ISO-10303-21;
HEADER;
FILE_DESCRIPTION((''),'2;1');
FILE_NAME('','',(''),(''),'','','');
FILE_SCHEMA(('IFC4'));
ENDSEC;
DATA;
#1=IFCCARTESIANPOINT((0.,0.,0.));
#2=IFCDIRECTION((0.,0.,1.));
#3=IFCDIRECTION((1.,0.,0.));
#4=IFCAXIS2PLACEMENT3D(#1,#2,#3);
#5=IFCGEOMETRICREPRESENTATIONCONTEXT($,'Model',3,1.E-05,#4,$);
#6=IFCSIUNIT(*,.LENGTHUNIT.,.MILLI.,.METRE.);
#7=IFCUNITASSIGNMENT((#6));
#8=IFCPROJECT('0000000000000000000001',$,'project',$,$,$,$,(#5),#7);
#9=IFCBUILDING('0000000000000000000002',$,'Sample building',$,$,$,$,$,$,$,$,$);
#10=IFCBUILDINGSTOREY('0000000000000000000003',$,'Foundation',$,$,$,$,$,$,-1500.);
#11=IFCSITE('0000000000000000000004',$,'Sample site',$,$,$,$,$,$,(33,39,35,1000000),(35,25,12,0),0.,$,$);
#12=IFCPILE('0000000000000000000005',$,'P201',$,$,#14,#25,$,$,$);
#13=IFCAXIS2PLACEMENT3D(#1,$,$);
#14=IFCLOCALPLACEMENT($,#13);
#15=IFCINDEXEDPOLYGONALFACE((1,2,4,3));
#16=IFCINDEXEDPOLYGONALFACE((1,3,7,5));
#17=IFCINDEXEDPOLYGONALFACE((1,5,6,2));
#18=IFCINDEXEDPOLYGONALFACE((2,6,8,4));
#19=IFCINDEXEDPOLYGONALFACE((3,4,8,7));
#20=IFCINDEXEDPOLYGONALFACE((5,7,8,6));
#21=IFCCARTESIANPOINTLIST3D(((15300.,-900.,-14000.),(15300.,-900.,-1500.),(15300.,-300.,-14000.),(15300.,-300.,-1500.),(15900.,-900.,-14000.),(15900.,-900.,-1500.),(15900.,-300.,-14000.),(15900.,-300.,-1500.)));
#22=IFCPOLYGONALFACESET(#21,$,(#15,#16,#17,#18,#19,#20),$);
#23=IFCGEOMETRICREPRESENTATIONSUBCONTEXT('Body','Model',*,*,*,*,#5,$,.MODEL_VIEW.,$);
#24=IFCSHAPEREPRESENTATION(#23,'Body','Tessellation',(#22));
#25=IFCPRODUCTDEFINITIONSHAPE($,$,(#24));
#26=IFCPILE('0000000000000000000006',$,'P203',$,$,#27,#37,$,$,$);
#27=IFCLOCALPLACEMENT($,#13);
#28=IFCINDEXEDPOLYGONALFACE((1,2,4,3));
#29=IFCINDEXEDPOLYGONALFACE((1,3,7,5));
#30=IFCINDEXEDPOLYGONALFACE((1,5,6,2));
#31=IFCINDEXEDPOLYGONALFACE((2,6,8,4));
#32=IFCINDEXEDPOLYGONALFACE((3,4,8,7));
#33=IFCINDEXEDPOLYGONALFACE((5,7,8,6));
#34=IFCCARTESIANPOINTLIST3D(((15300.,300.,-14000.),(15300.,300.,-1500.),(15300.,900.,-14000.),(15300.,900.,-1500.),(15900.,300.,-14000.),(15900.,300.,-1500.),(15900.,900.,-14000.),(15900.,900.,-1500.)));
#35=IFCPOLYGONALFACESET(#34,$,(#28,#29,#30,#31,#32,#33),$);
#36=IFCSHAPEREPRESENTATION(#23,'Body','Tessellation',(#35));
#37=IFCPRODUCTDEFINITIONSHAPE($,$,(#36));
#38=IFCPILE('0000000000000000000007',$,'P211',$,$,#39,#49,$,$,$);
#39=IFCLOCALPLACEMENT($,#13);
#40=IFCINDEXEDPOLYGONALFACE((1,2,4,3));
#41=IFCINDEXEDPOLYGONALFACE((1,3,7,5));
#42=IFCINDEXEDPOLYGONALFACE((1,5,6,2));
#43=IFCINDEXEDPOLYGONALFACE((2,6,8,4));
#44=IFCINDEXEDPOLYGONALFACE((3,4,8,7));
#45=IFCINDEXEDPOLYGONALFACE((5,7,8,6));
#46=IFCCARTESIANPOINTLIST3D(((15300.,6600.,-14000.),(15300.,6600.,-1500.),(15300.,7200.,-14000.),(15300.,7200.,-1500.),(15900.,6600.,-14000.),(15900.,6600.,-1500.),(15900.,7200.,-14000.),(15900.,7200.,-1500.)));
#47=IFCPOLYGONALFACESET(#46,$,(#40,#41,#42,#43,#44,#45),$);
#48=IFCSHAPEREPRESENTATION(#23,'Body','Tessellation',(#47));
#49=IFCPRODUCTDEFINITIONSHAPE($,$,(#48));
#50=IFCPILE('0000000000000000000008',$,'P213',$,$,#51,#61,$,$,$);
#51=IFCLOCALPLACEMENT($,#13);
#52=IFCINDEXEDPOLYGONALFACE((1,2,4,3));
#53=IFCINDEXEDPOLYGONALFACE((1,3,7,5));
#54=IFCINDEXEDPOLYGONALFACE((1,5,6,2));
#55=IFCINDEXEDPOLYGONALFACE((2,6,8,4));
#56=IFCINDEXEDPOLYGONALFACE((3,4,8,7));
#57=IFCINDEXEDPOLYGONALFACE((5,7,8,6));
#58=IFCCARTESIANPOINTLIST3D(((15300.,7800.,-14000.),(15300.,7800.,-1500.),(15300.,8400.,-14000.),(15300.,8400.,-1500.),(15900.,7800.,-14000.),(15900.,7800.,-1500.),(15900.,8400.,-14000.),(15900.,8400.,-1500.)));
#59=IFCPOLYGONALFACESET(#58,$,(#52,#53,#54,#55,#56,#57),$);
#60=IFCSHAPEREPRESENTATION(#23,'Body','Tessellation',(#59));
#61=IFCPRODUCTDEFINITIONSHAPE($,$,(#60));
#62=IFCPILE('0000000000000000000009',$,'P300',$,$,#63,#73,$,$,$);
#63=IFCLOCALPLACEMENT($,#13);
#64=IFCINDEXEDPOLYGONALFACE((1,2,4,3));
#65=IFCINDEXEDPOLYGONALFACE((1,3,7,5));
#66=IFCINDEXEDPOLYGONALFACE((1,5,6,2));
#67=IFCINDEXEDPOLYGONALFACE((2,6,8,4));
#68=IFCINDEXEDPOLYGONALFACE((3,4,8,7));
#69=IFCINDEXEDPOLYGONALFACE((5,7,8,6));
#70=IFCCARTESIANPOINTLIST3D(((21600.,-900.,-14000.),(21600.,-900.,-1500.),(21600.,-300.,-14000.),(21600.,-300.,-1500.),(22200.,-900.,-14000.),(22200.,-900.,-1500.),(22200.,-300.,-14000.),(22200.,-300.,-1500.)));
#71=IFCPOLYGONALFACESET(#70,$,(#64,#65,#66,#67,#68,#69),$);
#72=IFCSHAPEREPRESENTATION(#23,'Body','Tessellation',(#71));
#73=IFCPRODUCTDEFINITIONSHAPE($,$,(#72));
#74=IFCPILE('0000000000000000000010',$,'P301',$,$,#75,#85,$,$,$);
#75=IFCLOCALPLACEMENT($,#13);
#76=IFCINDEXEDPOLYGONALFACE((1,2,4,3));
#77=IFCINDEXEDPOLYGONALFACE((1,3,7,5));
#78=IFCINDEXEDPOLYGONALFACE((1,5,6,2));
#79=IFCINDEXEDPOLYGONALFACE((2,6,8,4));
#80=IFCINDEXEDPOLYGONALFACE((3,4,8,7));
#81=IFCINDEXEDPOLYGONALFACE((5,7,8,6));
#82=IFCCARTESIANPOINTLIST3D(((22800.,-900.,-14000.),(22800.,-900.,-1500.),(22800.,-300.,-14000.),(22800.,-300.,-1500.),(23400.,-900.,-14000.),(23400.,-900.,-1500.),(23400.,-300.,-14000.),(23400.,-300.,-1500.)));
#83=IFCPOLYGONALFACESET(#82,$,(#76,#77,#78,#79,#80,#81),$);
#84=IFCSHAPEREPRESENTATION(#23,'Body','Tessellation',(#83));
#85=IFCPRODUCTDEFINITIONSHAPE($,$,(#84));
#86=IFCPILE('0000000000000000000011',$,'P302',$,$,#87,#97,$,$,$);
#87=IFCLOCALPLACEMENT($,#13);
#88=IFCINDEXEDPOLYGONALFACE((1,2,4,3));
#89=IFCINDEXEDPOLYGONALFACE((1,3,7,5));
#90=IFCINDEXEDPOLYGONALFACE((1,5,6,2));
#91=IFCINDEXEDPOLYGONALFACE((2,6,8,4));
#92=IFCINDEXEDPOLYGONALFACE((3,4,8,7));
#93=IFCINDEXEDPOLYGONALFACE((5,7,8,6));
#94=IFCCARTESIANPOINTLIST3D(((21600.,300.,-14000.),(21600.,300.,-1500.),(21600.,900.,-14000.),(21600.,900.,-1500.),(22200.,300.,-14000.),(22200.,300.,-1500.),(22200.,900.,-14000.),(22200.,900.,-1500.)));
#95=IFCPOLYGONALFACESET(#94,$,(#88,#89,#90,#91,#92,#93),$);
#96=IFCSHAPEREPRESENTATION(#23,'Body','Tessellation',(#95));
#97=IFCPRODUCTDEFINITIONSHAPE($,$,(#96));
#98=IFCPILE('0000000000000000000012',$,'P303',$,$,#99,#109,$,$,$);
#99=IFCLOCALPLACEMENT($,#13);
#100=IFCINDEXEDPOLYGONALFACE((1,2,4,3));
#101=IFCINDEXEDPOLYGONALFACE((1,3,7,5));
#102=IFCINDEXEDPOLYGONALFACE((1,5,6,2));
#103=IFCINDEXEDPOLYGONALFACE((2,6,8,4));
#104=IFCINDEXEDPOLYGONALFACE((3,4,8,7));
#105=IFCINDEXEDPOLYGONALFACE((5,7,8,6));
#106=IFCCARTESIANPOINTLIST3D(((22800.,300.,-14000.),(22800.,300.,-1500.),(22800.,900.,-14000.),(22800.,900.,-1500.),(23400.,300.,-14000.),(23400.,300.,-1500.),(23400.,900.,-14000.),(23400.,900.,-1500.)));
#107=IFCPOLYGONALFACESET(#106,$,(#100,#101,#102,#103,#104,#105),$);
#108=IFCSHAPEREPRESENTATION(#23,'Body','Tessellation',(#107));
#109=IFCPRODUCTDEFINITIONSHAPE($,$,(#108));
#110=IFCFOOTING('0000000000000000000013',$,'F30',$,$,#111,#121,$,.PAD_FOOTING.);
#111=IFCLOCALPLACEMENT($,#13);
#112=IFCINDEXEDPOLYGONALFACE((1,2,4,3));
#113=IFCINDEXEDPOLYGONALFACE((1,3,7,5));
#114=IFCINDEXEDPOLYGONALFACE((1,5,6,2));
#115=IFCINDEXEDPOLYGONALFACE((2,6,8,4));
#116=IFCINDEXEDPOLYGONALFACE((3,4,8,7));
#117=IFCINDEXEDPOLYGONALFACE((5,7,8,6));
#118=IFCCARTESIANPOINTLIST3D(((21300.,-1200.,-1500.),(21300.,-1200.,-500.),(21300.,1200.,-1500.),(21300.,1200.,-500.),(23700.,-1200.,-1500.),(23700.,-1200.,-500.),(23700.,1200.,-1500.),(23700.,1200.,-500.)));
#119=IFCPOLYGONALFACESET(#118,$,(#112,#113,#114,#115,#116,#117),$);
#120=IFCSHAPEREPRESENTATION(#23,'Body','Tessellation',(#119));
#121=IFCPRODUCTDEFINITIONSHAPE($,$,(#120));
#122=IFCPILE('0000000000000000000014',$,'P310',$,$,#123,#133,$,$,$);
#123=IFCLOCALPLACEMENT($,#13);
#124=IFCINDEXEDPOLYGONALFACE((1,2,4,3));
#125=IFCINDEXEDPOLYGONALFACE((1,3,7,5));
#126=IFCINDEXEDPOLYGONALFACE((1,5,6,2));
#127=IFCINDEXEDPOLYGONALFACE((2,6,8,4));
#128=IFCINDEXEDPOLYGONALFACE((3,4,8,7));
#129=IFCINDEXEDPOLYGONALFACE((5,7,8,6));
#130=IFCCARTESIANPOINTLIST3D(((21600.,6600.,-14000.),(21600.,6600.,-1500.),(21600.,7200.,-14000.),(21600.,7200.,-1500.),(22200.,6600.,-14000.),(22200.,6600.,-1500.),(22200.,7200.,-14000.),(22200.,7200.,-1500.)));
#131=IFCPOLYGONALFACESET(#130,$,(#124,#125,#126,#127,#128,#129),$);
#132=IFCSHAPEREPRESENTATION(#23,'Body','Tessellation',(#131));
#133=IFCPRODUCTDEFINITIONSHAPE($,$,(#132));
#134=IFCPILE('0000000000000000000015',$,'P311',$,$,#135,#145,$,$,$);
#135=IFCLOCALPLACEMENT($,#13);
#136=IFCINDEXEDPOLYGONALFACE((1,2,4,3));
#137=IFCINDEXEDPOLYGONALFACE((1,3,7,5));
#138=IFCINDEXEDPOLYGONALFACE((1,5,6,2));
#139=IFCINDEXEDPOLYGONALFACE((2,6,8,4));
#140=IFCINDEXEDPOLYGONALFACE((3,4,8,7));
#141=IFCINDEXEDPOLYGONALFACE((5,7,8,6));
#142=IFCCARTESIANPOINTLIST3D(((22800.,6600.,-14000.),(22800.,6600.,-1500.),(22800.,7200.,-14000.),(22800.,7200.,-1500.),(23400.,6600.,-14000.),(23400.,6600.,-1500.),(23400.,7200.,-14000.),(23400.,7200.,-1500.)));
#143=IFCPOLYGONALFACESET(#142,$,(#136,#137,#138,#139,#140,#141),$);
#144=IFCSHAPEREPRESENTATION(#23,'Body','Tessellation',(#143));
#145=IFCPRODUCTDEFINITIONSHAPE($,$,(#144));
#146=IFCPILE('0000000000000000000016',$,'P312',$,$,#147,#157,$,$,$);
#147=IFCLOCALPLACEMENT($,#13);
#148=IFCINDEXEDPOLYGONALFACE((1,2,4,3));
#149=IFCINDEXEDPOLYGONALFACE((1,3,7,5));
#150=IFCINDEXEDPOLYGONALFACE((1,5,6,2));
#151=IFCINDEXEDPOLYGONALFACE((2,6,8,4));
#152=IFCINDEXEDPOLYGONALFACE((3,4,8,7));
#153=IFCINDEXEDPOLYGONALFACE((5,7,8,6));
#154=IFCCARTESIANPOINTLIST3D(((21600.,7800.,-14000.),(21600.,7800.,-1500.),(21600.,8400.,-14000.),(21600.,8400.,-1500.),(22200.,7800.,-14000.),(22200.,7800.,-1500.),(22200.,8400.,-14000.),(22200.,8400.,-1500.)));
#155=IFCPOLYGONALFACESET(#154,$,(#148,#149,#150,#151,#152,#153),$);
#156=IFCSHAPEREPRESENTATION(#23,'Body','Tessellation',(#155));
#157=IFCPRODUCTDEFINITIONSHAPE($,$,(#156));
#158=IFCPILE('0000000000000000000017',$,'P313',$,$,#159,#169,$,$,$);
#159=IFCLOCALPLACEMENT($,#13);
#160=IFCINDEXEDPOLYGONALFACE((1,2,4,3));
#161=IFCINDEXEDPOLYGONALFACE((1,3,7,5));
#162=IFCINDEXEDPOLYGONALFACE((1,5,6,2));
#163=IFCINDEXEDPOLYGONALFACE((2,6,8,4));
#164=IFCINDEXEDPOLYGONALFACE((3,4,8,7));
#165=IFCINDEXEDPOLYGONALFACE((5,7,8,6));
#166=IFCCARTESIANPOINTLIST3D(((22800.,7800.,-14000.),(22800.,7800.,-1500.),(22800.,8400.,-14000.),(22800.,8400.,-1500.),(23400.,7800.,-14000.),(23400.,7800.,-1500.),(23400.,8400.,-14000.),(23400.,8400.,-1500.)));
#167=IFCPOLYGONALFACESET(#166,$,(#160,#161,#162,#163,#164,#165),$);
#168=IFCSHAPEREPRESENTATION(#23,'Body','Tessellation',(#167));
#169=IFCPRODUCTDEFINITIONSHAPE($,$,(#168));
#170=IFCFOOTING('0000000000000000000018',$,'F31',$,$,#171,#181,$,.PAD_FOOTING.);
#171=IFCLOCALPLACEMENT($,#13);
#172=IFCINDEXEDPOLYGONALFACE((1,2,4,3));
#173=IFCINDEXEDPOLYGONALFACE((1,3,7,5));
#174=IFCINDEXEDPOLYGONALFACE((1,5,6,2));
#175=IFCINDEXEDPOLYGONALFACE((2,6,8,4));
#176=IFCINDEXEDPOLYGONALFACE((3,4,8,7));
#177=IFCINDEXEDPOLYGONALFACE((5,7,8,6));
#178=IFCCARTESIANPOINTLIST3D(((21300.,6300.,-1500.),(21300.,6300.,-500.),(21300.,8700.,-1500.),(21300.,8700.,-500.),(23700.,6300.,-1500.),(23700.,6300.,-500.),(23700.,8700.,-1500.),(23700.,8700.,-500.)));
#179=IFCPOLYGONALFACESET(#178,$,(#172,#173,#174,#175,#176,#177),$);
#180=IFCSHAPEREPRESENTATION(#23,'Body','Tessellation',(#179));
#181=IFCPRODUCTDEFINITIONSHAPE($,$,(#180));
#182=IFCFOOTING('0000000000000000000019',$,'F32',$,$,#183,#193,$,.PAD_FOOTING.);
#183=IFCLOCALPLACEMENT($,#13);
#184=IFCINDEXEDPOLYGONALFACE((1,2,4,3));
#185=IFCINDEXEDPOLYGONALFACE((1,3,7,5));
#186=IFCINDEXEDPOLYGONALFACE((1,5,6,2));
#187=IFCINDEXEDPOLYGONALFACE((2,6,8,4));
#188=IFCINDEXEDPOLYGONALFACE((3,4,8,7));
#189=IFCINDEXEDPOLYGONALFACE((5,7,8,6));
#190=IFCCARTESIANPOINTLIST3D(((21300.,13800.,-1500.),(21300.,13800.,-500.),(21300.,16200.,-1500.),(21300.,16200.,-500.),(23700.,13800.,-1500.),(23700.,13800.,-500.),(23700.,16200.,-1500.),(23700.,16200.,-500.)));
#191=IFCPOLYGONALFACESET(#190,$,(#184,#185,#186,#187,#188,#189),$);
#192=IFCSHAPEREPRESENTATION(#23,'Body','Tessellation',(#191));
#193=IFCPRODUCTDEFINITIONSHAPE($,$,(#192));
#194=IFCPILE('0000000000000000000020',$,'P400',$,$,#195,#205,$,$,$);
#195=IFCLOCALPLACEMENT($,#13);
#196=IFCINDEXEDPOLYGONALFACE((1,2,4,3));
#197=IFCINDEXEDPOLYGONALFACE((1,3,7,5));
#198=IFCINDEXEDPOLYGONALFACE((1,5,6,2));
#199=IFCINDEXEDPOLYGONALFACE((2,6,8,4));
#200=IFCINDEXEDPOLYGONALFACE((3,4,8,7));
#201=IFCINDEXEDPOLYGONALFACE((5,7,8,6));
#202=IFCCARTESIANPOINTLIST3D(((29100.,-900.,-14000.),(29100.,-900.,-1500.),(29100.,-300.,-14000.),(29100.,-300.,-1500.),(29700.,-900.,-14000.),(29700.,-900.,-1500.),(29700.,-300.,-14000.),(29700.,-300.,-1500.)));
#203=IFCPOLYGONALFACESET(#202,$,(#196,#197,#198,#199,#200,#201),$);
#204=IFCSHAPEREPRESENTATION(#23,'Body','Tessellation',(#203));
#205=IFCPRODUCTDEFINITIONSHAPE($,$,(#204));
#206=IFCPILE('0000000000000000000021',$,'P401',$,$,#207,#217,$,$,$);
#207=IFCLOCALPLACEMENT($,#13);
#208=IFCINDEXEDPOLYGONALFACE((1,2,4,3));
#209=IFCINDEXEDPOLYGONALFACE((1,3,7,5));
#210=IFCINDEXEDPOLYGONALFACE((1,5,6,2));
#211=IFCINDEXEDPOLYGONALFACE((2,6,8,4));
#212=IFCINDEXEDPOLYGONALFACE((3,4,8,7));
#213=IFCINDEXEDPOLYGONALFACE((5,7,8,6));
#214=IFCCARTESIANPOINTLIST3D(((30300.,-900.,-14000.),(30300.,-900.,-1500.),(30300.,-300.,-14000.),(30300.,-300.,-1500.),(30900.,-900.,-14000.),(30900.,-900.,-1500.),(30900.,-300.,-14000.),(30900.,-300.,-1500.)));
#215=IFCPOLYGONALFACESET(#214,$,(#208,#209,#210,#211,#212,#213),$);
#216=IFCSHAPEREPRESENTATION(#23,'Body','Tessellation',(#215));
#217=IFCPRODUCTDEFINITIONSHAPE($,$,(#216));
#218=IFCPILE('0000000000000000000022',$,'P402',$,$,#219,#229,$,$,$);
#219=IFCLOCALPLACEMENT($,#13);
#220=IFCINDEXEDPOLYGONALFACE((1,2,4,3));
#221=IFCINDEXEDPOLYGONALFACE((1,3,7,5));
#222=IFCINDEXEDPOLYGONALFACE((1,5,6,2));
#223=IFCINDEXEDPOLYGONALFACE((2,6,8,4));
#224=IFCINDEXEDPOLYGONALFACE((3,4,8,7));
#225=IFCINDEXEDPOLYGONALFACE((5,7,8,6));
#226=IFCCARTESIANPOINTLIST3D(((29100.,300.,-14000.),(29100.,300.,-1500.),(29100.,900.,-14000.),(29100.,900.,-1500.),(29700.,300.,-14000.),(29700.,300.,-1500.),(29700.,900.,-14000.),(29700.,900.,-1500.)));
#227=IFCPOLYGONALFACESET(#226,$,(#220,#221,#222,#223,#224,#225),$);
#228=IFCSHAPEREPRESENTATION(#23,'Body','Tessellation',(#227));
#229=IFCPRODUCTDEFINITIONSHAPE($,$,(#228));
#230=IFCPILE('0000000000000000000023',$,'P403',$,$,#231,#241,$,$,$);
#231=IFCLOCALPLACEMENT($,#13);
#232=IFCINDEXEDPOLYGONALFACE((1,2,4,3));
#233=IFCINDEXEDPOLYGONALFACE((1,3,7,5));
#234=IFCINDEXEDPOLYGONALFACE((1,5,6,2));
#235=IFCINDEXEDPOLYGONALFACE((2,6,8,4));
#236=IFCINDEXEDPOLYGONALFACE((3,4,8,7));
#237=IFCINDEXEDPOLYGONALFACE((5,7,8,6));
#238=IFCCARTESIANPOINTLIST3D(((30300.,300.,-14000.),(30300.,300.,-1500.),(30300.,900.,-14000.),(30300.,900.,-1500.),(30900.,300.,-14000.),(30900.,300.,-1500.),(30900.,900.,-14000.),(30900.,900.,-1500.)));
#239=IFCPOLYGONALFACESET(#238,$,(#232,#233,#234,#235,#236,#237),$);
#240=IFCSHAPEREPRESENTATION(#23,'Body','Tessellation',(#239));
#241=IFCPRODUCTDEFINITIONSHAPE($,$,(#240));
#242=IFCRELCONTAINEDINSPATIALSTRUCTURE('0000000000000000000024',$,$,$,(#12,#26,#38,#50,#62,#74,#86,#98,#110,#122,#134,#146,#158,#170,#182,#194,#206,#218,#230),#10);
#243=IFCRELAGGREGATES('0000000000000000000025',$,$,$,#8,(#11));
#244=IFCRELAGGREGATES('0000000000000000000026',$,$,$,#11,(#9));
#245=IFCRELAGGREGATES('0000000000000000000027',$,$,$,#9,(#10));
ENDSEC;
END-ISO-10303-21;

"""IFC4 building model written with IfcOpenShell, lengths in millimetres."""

from ifc_helpers import new_model, si_unit, frame, origin_with_axes, place, context, subcontext, project, spatial, indexed_curve, outline, extrude, element, save


model = new_model("IFC4")

# Units and contexts
model_context = context("Model", 3, precision=1e-05, world=origin_with_axes())
body_context = subcontext(model_context, "Body", "Model", "MODEL_VIEW")
ifc_project = project(units=[si_unit("LENGTHUNIT", "METRE", prefix="MILLI")], contexts=[model_context])

# Site, building, storey
site = spatial("IfcSite", under=ifc_project, Name="Sample site", RefLatitude=(33, 39, 35, 1000000), RefLongitude=(35, 25, 12, 0), RefElevation=0.0)
building = spatial("IfcBuilding", under=site, Name="Sample building")
storey = spatial("IfcBuildingStorey", under=building, Name="Foundation", Elevation=-1500.0)

# Piles
for number, where, z_axis, x_axis, name in (
    (1, (15300.0, -900.0, -14000.0), (0.0, 0.0, 1.0), (1.0, 0.0, 0.0), "P201"),
    (2, (15300.0, 300.0, -14000.0), (0.0, 0.0, 1.0), (1.0, 0.0, 0.0), "P203"),
    (3, (15300.0, 6600.0, -14000.0), (0.0, 0.0, 1.0), (1.0, 0.0, 0.0), "P211"),
    (4, (15300.0, 7800.0, -14000.0), (0.0, 0.0, 1.0), (1.0, 0.0, 0.0), "P213"),
    (5, (21600.0, -900.0, -14000.0), (0.0, 0.0, 1.0), (1.0, 0.0, 0.0), "P300"),
    (6, (22800.0, -900.0, -14000.0), (0.0, 0.0, 1.0), (1.0, 0.0, 0.0), "P301"),
    (7, (21600.0, 300.0, -14000.0), (0.0, 0.0, 1.0), (1.0, 0.0, 0.0), "P302"),
    (8, (22800.0, 300.0, -14000.0), (0.0, 0.0, 1.0), (1.0, 0.0, 0.0), "P303"),
):
    element("IfcPile", number, at=place(None, frame(where, z_axis=z_axis, x_axis=x_axis)), inside=storey, Name=name, context=body_context, shape_type="SweptSolid", body=[
        extrude(outline(indexed_curve([(0.0, 0.0), (0.0, 600.0), (600.0, 600.0), (600.0, 0.0), (0.0, 0.0)], self_intersect=False)), origin_with_axes(), (0.0, 0.0, 1.0), 12500.0),
    ])

# Footing
footing_1_placement = place(None, frame((21300.0, -1200.0, -1500.0), z_axis=(0.0, 0.0, 1.0), x_axis=(1.0, 0.0, 0.0)))
element("IfcFooting", 9, at=footing_1_placement, inside=storey, Name="F30", PredefinedType="PAD_FOOTING", context=body_context, shape_type="SweptSolid", body=[
    extrude(outline(indexed_curve([(0.0, 0.0), (0.0, 2400.0), (2400.0, 2400.0), (2400.0, 0.0), (0.0, 0.0)], self_intersect=False)), origin_with_axes(), (0.0, 0.0, 1.0), 1000.0),
])

# Piles
for number, where, z_axis, x_axis, name in (
    (10, (21600.0, 6600.0, -14000.0), (0.0, 0.0, 1.0), (1.0, 0.0, 0.0), "P310"),
    (11, (22800.0, 6600.0, -14000.0), (0.0, 0.0, 1.0), (1.0, 0.0, 0.0), "P311"),
    (12, (21600.0, 7800.0, -14000.0), (0.0, 0.0, 1.0), (1.0, 0.0, 0.0), "P312"),
    (13, (22800.0, 7800.0, -14000.0), (0.0, 0.0, 1.0), (1.0, 0.0, 0.0), "P313"),
):
    element("IfcPile", number, at=place(None, frame(where, z_axis=z_axis, x_axis=x_axis)), inside=storey, Name=name, context=body_context, shape_type="SweptSolid", body=[
        extrude(outline(indexed_curve([(0.0, 0.0), (0.0, 600.0), (600.0, 600.0), (600.0, 0.0), (0.0, 0.0)], self_intersect=False)), origin_with_axes(), (0.0, 0.0, 1.0), 12500.0),
    ])

# Footings
for number, where, z_axis, x_axis, name in (
    (14, (21300.0, 6300.0, -1500.0), (0.0, 0.0, 1.0), (1.0, 0.0, 0.0), "F31"),
    (15, (21300.0, 13800.0, -1500.0), (0.0, 0.0, 1.0), (1.0, 0.0, 0.0), "F32"),
):
    element("IfcFooting", number, at=place(None, frame(where, z_axis=z_axis, x_axis=x_axis)), inside=storey, Name=name, PredefinedType="PAD_FOOTING", context=body_context, shape_type="SweptSolid", body=[
        extrude(outline(indexed_curve([(0.0, 0.0), (0.0, 2400.0), (2400.0, 2400.0), (2400.0, 0.0), (0.0, 0.0)], self_intersect=False)), origin_with_axes(), (0.0, 0.0, 1.0), 1000.0),
    ])

# Piles
for number, where, z_axis, x_axis, name in (
    (16, (29100.0, -900.0, -14000.0), (0.0, 0.0, 1.0), (1.0, 0.0, 0.0), "P400"),
    (17, (30300.0, -900.0, -14000.0), (0.0, 0.0, 1.0), (1.0, 0.0, 0.0), "P401"),
    (18, (29100.0, 300.0, -14000.0), (0.0, 0.0, 1.0), (1.0, 0.0, 0.0), "P402"),
    (19, (30300.0, 300.0, -14000.0), (0.0, 0.0, 1.0), (1.0, 0.0, 0.0), "P403"),
):
    element("IfcPile", number, at=place(None, frame(where, z_axis=z_axis, x_axis=x_axis)), inside=storey, Name=name, context=body_context, shape_type="SweptSolid", body=[
        extrude(outline(indexed_curve([(0.0, 0.0), (0.0, 600.0), (600.0, 600.0), (600.0, 0.0), (0.0, 0.0)], self_intersect=False)), origin_with_axes(), (0.0, 0.0, 1.0), 12500.0),
    ])

save(model, "model.ifc")
